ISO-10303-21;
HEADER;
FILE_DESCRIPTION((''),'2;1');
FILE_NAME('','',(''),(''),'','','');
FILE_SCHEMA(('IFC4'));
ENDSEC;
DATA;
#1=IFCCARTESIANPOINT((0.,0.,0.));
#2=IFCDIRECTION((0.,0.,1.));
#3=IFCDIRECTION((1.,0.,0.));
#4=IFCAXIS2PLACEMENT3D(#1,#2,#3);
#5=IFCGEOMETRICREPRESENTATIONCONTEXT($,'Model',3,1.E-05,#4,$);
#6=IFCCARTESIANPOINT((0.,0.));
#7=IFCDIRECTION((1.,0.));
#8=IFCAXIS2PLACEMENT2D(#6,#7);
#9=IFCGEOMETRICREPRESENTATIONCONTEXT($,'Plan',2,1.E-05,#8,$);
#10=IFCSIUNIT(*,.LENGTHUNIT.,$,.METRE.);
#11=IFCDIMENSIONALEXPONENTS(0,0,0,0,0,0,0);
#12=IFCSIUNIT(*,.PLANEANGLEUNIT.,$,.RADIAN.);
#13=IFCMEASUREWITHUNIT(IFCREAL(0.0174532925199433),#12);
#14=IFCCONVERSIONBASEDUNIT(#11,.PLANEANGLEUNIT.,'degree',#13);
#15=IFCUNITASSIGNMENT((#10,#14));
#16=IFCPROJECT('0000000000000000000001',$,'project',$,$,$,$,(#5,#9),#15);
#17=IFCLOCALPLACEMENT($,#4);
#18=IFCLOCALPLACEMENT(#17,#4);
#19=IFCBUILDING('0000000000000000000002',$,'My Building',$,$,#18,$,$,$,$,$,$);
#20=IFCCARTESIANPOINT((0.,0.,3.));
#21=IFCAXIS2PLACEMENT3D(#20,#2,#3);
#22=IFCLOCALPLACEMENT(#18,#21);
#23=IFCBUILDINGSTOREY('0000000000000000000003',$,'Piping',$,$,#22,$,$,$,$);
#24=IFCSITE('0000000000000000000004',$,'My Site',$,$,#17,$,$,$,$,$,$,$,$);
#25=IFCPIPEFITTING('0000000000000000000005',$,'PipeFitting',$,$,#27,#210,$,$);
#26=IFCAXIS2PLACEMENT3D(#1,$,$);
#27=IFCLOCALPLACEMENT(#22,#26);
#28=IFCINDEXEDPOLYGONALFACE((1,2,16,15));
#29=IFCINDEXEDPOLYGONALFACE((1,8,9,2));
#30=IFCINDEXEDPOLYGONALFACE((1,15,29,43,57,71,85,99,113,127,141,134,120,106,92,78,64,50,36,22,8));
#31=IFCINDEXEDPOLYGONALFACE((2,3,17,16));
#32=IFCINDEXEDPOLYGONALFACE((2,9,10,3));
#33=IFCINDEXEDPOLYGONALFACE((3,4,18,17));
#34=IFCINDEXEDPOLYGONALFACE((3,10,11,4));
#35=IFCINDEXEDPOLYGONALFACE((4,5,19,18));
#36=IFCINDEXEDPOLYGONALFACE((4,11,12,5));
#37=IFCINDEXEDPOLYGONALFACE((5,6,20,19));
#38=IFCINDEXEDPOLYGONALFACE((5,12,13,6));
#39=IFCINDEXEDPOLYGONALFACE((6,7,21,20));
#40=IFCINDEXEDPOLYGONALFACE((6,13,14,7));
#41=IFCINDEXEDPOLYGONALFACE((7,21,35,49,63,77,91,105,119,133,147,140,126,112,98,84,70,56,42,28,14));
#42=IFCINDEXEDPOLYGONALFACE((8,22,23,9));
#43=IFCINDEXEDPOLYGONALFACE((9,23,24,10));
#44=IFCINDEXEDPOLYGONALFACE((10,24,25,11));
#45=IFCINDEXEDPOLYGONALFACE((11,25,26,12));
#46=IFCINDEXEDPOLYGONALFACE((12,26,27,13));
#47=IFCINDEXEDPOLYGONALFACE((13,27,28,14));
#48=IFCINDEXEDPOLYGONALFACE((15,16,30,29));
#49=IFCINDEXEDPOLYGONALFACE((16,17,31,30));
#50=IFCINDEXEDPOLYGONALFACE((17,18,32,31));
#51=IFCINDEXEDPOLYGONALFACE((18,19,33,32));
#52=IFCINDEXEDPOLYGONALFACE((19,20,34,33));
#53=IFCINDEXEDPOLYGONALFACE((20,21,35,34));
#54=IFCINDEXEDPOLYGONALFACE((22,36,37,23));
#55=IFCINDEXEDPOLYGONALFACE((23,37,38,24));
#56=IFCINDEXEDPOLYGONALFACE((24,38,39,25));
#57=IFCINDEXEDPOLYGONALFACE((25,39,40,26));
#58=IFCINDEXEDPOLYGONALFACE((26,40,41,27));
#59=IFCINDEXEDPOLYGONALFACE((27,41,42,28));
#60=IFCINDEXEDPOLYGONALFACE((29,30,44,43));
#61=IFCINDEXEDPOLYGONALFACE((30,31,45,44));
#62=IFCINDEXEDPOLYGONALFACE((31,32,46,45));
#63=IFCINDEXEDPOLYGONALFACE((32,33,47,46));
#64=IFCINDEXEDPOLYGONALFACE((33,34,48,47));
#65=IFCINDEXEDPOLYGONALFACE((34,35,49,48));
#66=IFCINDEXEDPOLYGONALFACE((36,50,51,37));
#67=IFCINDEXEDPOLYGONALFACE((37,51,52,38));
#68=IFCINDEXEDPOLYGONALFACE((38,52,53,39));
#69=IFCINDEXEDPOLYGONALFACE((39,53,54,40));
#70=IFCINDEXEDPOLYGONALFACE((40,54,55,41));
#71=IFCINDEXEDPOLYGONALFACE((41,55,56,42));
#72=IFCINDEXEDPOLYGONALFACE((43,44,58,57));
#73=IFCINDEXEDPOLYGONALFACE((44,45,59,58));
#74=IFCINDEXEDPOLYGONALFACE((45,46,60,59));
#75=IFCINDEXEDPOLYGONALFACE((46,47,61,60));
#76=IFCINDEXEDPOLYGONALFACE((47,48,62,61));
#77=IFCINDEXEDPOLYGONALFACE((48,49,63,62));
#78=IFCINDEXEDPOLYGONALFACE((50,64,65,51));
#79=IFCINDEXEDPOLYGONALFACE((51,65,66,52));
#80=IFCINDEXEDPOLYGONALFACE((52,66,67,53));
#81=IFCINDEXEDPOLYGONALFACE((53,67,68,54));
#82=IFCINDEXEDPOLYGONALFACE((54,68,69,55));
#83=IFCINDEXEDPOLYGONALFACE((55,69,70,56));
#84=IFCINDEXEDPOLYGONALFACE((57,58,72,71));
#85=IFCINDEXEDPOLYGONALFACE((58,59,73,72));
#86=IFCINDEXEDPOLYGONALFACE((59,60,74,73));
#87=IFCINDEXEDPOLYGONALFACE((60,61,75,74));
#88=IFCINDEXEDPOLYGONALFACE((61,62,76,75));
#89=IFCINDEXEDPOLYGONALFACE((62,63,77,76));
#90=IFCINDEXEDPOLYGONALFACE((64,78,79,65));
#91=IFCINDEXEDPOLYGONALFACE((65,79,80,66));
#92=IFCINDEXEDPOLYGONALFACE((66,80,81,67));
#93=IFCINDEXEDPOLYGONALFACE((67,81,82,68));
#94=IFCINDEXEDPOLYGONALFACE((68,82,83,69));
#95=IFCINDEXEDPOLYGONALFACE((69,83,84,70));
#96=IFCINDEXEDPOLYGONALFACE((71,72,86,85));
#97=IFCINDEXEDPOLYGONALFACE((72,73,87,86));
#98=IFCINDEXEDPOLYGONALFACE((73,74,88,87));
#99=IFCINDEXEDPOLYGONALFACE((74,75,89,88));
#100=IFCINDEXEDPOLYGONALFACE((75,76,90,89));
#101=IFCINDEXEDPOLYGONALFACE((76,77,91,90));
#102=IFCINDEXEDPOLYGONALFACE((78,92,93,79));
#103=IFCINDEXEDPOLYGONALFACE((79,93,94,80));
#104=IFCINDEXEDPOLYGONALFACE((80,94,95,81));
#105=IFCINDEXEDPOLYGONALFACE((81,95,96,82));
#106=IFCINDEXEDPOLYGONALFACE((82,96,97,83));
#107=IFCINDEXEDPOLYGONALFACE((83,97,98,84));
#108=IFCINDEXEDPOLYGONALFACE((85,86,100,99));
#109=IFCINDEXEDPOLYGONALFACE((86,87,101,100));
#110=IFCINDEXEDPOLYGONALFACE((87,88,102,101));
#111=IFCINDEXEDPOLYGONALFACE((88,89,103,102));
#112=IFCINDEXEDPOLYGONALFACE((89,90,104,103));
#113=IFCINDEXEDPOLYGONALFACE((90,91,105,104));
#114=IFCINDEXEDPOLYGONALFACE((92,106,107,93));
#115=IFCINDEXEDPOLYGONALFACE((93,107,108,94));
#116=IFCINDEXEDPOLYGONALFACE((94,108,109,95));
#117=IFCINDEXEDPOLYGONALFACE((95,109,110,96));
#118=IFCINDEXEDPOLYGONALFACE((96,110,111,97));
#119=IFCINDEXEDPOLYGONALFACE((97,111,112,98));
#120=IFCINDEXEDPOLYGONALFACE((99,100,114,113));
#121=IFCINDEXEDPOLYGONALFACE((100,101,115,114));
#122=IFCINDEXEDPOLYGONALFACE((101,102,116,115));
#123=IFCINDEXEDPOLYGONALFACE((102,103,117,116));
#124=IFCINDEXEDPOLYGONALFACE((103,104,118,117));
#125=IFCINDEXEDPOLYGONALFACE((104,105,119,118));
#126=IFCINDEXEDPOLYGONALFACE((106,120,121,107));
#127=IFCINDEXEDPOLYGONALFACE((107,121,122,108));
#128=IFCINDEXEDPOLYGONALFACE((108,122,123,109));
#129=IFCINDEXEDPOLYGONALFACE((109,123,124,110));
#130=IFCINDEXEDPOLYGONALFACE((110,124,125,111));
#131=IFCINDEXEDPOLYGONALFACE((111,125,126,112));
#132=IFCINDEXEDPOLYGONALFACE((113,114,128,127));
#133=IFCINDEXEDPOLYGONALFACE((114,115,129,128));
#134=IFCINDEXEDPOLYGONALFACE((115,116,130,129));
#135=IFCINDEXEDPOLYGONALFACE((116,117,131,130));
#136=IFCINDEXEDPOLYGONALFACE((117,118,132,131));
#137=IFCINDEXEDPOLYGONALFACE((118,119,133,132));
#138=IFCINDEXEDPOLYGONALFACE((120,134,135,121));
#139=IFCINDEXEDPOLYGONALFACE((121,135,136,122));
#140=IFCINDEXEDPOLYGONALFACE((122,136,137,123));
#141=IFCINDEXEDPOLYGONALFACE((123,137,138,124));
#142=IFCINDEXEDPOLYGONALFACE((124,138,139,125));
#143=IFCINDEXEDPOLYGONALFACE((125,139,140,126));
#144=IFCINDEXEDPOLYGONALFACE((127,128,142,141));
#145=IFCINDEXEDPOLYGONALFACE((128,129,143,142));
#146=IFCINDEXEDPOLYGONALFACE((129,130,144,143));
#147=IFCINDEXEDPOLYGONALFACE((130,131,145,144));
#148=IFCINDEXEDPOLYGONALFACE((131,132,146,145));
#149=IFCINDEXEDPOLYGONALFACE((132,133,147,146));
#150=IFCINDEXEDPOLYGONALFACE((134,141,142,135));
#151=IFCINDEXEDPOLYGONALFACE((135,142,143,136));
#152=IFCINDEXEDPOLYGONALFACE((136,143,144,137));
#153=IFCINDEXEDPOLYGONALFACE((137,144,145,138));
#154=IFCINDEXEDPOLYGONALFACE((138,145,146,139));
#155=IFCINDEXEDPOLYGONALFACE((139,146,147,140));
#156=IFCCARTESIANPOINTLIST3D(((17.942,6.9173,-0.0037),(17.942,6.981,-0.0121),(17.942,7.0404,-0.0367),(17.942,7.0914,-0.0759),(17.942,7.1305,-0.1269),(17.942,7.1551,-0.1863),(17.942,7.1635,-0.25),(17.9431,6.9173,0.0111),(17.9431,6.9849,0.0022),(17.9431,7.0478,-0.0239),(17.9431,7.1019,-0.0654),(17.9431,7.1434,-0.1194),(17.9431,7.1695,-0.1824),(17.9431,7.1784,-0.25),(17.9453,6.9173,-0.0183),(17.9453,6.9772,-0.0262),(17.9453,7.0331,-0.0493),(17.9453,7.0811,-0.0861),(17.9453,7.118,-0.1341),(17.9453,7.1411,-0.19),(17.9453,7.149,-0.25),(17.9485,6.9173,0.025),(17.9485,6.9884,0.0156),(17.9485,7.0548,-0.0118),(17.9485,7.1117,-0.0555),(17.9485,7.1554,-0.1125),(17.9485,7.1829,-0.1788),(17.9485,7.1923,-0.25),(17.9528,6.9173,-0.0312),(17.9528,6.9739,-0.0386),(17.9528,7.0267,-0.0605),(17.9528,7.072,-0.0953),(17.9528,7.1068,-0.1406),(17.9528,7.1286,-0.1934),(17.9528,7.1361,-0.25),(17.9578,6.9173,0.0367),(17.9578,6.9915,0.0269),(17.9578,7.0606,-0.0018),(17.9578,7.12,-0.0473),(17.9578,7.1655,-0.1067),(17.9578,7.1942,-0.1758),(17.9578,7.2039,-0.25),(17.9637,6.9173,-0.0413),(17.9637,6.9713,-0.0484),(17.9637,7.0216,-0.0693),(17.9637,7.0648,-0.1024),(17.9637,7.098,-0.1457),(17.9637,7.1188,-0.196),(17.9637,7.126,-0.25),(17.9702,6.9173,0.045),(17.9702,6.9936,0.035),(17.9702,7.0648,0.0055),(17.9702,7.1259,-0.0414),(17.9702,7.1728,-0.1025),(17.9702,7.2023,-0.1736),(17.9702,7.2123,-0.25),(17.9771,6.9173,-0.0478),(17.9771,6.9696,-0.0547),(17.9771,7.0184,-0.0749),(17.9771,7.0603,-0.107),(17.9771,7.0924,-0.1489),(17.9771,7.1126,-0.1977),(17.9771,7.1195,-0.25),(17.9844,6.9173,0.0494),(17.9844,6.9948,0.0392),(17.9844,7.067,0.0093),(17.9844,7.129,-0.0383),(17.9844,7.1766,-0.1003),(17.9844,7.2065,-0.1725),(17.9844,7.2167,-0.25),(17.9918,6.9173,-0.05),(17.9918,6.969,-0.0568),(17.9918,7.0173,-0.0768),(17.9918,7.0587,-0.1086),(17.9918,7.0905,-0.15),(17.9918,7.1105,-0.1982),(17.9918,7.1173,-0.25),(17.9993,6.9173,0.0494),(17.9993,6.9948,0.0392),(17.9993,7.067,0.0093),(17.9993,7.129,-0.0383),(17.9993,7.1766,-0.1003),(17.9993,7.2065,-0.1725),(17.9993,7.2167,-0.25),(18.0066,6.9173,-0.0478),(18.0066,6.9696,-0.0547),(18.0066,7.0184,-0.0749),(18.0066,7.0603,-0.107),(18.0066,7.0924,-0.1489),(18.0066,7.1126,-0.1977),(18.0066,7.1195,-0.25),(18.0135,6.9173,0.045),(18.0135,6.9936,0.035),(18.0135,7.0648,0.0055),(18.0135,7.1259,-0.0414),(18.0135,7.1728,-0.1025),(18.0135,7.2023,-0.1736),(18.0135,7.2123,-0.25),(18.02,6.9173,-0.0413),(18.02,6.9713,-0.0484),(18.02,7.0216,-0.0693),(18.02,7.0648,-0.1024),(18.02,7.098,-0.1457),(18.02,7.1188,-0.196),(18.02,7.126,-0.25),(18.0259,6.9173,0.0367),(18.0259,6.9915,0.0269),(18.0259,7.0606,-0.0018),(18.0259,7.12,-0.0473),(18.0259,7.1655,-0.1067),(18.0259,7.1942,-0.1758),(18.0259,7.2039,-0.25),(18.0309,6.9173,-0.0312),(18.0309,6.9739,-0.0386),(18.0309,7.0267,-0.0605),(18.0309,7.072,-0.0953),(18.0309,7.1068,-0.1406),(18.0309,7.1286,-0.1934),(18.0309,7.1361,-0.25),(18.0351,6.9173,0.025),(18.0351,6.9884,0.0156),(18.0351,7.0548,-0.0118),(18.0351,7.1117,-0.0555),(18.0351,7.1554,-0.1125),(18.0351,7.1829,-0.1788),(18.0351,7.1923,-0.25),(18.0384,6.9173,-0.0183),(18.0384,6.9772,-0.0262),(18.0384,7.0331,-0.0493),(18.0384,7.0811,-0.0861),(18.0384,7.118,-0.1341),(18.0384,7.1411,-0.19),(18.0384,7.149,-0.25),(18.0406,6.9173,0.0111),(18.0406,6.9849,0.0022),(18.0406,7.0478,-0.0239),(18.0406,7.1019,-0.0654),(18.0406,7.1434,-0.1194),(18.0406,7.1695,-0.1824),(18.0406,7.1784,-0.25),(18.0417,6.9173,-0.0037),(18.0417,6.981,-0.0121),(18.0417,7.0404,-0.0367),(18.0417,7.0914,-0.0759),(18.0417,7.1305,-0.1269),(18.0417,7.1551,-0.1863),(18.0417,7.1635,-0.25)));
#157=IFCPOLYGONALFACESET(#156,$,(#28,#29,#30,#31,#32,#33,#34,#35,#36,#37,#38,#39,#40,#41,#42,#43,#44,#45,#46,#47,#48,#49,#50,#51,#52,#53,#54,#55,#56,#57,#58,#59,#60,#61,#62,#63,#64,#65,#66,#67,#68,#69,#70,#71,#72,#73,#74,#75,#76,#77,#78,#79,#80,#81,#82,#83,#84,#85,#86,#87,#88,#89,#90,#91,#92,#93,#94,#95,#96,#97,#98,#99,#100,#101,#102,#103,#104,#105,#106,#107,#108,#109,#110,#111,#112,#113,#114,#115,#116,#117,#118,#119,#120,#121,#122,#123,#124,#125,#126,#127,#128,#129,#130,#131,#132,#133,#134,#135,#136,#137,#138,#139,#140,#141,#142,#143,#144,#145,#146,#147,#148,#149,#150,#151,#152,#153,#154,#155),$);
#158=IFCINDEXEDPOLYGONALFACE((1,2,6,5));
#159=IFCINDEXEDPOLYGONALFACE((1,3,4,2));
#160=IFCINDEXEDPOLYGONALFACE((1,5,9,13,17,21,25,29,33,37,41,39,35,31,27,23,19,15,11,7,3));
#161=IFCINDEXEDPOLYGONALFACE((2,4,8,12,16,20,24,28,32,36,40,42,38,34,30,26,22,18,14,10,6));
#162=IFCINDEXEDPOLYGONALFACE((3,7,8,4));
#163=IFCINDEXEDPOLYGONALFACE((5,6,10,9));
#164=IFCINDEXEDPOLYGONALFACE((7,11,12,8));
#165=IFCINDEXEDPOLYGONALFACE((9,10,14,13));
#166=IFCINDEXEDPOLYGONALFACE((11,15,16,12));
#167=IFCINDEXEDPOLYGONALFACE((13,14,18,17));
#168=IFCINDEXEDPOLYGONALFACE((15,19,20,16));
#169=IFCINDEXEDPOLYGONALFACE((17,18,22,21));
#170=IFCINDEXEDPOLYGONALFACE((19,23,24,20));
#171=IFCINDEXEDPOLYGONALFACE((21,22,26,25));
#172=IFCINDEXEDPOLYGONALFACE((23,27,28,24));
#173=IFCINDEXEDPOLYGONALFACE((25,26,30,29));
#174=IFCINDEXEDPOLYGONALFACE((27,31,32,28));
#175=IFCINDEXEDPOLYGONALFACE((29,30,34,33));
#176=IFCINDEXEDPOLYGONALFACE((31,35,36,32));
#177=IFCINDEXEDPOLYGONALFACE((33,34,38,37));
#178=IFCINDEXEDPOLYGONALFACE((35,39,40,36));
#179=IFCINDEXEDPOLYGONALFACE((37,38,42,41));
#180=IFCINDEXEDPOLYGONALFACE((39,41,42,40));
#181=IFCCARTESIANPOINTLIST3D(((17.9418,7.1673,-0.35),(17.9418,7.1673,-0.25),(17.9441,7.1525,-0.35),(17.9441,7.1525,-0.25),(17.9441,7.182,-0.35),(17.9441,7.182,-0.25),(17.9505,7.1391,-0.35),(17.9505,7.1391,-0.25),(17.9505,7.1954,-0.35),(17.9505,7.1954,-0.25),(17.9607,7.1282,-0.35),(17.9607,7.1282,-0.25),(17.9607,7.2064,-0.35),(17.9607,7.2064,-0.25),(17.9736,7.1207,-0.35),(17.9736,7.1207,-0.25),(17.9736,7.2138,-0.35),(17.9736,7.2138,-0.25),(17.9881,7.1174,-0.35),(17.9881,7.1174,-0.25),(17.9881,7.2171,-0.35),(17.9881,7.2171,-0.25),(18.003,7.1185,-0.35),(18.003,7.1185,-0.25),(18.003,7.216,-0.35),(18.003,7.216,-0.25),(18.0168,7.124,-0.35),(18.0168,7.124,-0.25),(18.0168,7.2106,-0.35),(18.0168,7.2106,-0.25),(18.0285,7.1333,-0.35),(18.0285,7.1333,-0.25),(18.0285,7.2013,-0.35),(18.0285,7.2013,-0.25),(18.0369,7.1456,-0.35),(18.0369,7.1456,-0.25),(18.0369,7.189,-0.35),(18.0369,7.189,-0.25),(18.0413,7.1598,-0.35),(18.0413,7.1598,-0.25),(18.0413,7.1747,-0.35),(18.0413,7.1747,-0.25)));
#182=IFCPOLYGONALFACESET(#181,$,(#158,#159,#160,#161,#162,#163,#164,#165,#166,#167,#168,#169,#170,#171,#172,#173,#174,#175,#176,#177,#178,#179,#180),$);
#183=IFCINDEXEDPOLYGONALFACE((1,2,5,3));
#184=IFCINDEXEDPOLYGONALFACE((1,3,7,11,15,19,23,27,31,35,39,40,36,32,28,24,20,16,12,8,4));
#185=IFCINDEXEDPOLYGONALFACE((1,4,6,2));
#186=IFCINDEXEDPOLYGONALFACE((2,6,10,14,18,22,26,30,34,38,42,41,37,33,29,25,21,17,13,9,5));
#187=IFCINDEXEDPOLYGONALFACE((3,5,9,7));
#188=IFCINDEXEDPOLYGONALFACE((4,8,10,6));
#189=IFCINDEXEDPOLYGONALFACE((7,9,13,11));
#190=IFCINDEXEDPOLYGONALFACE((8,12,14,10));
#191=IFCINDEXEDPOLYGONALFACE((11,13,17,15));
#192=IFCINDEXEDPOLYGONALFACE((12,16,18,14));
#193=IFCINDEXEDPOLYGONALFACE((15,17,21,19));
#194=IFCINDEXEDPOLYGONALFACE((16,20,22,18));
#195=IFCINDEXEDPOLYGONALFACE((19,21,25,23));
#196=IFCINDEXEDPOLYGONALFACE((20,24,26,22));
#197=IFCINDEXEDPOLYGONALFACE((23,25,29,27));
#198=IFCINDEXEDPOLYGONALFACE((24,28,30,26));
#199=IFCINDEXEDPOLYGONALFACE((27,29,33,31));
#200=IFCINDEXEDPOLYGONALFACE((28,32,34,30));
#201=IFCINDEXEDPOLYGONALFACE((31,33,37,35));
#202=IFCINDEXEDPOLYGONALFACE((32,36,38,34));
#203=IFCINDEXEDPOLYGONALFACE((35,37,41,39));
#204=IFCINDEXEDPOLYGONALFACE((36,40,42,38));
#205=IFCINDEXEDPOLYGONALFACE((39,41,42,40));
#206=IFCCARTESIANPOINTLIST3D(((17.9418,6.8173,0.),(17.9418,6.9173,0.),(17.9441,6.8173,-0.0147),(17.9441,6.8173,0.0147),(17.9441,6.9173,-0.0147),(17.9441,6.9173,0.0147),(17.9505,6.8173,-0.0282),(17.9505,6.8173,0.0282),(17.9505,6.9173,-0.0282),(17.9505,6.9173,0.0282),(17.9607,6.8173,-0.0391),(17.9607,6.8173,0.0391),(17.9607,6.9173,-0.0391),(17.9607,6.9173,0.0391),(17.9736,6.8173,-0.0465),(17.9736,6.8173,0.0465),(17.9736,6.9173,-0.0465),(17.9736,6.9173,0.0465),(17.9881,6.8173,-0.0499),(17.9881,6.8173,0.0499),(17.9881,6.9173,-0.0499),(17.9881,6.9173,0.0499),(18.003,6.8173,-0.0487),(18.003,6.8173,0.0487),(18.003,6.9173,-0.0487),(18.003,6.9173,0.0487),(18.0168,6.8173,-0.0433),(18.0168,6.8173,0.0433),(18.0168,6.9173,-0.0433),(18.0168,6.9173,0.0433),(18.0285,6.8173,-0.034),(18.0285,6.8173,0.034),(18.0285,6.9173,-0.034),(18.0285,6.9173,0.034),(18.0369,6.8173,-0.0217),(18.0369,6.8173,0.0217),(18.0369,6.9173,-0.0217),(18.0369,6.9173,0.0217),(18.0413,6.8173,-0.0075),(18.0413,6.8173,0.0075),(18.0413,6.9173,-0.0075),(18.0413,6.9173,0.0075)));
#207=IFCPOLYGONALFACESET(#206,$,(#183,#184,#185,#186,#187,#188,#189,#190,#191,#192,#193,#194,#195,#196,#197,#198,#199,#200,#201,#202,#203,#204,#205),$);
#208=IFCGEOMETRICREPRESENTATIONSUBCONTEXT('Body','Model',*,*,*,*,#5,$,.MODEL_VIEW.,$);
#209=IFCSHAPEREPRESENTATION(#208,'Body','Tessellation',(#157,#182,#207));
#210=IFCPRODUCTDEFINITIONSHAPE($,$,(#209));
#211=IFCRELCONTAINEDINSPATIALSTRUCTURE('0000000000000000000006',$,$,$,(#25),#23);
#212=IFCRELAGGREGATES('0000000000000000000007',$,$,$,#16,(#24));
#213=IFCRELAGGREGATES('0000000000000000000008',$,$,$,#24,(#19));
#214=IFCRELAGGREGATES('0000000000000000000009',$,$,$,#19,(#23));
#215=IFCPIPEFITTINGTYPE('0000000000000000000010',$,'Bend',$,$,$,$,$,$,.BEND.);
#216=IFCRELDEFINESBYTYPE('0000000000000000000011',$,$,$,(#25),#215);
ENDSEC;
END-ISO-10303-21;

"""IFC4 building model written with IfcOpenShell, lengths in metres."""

from ifc_helpers import new_model, entity, si_unit, converted_unit, frame, origin_with_axes, origin_2d_with_axis, place, context, subcontext, project, spatial, circle, extrude, source, transform, mapped, type_object, type_shapes, element, save


model = new_model("IFC4")

# Units and contexts
model_context = context("Model", 3, precision=1e-05, world=origin_with_axes())
plan_context = context("Plan", 2, precision=1e-05, world=origin_2d_with_axis())
body_context = subcontext(model_context, "Body", "Model", "MODEL_VIEW")
ifc_project = project(units=[si_unit("LENGTHUNIT", "METRE"), converted_unit("PLANEANGLEUNIT", "degree", entity("IfcReal", 0.0174532925199433), si_unit("PLANEANGLEUNIT", "RADIAN"), dimensions=[0, 0, 0, 0, 0, 0, 0])], contexts=[model_context, plan_context])

# Site, building, storey
site_placement = place(None, origin_with_axes())
site = spatial("IfcSite", under=ifc_project, at=site_placement, Name="My Site")
building_placement = place(site_placement, origin_with_axes())
building = spatial("IfcBuilding", under=site, at=building_placement, Name="My Building")
storey_placement = place(building_placement, frame((0.0, 0.0, 3.0), z_axis=(0.0, 0.0, 1.0), x_axis=(1.0, 0.0, 0.0)))
storey = spatial("IfcBuildingStorey", under=building, at=storey_placement, Name="Piping")

# Pipe fitting
pipe_fitting_type = type_object("IfcPipeFittingType", Name="Bend", PredefinedType="BEND")
shared_shape = source(origin_with_axes(), body_context, "Body", "SolidModel", [
    entity("IfcSweptDiskSolid", entity("IfcIndexedPolyCurve", entity("IfcCartesianPointList3D", [[0.0, 0.0, -0.1], [0.0, -0.0732, -0.2768], [0.0, -0.25, -0.35]]), [entity("IfcArcIndex", [1, 2, 3])]), 0.05),
    extrude(circle(Radius=0.05), origin_with_axes(), (0.0, 0.0, -1.0), 0.1),
    extrude(circle(Radius=0.05), frame((0.0, -0.25, -0.35), z_axis=(0.0, -1.0, 0.0), x_axis=(1.0, 0.0, 0.0)), (0.0, 0.0, 1.0), 0.1),
])
type_shapes(pipe_fitting_type, [shared_shape])
for number, where, z_axis, x_axis, name in (
    (1, (17.9918, 7.1673, -0.35), (0.0, 0.0, -1.0), (-1.0, 0.0, 0.0), "PipeFitting"),
):
    element("IfcPipeFitting", number, at=place(storey_placement, frame(where, z_axis=z_axis, x_axis=x_axis)), inside=storey, type_object=pipe_fitting_type, Name=name, context=body_context, shape_type="MappedRepresentation", body=[
        mapped(shared_shape, transform((0.0, 0.0, 0.0), x_axis=(1.0, 0.0, 0.0), y_axis=(0.0, 1.0, 0.0), z_axis=(0.0, 0.0, 1.0), scale=1.0)),
    ])

save(model, "model.ifc")
